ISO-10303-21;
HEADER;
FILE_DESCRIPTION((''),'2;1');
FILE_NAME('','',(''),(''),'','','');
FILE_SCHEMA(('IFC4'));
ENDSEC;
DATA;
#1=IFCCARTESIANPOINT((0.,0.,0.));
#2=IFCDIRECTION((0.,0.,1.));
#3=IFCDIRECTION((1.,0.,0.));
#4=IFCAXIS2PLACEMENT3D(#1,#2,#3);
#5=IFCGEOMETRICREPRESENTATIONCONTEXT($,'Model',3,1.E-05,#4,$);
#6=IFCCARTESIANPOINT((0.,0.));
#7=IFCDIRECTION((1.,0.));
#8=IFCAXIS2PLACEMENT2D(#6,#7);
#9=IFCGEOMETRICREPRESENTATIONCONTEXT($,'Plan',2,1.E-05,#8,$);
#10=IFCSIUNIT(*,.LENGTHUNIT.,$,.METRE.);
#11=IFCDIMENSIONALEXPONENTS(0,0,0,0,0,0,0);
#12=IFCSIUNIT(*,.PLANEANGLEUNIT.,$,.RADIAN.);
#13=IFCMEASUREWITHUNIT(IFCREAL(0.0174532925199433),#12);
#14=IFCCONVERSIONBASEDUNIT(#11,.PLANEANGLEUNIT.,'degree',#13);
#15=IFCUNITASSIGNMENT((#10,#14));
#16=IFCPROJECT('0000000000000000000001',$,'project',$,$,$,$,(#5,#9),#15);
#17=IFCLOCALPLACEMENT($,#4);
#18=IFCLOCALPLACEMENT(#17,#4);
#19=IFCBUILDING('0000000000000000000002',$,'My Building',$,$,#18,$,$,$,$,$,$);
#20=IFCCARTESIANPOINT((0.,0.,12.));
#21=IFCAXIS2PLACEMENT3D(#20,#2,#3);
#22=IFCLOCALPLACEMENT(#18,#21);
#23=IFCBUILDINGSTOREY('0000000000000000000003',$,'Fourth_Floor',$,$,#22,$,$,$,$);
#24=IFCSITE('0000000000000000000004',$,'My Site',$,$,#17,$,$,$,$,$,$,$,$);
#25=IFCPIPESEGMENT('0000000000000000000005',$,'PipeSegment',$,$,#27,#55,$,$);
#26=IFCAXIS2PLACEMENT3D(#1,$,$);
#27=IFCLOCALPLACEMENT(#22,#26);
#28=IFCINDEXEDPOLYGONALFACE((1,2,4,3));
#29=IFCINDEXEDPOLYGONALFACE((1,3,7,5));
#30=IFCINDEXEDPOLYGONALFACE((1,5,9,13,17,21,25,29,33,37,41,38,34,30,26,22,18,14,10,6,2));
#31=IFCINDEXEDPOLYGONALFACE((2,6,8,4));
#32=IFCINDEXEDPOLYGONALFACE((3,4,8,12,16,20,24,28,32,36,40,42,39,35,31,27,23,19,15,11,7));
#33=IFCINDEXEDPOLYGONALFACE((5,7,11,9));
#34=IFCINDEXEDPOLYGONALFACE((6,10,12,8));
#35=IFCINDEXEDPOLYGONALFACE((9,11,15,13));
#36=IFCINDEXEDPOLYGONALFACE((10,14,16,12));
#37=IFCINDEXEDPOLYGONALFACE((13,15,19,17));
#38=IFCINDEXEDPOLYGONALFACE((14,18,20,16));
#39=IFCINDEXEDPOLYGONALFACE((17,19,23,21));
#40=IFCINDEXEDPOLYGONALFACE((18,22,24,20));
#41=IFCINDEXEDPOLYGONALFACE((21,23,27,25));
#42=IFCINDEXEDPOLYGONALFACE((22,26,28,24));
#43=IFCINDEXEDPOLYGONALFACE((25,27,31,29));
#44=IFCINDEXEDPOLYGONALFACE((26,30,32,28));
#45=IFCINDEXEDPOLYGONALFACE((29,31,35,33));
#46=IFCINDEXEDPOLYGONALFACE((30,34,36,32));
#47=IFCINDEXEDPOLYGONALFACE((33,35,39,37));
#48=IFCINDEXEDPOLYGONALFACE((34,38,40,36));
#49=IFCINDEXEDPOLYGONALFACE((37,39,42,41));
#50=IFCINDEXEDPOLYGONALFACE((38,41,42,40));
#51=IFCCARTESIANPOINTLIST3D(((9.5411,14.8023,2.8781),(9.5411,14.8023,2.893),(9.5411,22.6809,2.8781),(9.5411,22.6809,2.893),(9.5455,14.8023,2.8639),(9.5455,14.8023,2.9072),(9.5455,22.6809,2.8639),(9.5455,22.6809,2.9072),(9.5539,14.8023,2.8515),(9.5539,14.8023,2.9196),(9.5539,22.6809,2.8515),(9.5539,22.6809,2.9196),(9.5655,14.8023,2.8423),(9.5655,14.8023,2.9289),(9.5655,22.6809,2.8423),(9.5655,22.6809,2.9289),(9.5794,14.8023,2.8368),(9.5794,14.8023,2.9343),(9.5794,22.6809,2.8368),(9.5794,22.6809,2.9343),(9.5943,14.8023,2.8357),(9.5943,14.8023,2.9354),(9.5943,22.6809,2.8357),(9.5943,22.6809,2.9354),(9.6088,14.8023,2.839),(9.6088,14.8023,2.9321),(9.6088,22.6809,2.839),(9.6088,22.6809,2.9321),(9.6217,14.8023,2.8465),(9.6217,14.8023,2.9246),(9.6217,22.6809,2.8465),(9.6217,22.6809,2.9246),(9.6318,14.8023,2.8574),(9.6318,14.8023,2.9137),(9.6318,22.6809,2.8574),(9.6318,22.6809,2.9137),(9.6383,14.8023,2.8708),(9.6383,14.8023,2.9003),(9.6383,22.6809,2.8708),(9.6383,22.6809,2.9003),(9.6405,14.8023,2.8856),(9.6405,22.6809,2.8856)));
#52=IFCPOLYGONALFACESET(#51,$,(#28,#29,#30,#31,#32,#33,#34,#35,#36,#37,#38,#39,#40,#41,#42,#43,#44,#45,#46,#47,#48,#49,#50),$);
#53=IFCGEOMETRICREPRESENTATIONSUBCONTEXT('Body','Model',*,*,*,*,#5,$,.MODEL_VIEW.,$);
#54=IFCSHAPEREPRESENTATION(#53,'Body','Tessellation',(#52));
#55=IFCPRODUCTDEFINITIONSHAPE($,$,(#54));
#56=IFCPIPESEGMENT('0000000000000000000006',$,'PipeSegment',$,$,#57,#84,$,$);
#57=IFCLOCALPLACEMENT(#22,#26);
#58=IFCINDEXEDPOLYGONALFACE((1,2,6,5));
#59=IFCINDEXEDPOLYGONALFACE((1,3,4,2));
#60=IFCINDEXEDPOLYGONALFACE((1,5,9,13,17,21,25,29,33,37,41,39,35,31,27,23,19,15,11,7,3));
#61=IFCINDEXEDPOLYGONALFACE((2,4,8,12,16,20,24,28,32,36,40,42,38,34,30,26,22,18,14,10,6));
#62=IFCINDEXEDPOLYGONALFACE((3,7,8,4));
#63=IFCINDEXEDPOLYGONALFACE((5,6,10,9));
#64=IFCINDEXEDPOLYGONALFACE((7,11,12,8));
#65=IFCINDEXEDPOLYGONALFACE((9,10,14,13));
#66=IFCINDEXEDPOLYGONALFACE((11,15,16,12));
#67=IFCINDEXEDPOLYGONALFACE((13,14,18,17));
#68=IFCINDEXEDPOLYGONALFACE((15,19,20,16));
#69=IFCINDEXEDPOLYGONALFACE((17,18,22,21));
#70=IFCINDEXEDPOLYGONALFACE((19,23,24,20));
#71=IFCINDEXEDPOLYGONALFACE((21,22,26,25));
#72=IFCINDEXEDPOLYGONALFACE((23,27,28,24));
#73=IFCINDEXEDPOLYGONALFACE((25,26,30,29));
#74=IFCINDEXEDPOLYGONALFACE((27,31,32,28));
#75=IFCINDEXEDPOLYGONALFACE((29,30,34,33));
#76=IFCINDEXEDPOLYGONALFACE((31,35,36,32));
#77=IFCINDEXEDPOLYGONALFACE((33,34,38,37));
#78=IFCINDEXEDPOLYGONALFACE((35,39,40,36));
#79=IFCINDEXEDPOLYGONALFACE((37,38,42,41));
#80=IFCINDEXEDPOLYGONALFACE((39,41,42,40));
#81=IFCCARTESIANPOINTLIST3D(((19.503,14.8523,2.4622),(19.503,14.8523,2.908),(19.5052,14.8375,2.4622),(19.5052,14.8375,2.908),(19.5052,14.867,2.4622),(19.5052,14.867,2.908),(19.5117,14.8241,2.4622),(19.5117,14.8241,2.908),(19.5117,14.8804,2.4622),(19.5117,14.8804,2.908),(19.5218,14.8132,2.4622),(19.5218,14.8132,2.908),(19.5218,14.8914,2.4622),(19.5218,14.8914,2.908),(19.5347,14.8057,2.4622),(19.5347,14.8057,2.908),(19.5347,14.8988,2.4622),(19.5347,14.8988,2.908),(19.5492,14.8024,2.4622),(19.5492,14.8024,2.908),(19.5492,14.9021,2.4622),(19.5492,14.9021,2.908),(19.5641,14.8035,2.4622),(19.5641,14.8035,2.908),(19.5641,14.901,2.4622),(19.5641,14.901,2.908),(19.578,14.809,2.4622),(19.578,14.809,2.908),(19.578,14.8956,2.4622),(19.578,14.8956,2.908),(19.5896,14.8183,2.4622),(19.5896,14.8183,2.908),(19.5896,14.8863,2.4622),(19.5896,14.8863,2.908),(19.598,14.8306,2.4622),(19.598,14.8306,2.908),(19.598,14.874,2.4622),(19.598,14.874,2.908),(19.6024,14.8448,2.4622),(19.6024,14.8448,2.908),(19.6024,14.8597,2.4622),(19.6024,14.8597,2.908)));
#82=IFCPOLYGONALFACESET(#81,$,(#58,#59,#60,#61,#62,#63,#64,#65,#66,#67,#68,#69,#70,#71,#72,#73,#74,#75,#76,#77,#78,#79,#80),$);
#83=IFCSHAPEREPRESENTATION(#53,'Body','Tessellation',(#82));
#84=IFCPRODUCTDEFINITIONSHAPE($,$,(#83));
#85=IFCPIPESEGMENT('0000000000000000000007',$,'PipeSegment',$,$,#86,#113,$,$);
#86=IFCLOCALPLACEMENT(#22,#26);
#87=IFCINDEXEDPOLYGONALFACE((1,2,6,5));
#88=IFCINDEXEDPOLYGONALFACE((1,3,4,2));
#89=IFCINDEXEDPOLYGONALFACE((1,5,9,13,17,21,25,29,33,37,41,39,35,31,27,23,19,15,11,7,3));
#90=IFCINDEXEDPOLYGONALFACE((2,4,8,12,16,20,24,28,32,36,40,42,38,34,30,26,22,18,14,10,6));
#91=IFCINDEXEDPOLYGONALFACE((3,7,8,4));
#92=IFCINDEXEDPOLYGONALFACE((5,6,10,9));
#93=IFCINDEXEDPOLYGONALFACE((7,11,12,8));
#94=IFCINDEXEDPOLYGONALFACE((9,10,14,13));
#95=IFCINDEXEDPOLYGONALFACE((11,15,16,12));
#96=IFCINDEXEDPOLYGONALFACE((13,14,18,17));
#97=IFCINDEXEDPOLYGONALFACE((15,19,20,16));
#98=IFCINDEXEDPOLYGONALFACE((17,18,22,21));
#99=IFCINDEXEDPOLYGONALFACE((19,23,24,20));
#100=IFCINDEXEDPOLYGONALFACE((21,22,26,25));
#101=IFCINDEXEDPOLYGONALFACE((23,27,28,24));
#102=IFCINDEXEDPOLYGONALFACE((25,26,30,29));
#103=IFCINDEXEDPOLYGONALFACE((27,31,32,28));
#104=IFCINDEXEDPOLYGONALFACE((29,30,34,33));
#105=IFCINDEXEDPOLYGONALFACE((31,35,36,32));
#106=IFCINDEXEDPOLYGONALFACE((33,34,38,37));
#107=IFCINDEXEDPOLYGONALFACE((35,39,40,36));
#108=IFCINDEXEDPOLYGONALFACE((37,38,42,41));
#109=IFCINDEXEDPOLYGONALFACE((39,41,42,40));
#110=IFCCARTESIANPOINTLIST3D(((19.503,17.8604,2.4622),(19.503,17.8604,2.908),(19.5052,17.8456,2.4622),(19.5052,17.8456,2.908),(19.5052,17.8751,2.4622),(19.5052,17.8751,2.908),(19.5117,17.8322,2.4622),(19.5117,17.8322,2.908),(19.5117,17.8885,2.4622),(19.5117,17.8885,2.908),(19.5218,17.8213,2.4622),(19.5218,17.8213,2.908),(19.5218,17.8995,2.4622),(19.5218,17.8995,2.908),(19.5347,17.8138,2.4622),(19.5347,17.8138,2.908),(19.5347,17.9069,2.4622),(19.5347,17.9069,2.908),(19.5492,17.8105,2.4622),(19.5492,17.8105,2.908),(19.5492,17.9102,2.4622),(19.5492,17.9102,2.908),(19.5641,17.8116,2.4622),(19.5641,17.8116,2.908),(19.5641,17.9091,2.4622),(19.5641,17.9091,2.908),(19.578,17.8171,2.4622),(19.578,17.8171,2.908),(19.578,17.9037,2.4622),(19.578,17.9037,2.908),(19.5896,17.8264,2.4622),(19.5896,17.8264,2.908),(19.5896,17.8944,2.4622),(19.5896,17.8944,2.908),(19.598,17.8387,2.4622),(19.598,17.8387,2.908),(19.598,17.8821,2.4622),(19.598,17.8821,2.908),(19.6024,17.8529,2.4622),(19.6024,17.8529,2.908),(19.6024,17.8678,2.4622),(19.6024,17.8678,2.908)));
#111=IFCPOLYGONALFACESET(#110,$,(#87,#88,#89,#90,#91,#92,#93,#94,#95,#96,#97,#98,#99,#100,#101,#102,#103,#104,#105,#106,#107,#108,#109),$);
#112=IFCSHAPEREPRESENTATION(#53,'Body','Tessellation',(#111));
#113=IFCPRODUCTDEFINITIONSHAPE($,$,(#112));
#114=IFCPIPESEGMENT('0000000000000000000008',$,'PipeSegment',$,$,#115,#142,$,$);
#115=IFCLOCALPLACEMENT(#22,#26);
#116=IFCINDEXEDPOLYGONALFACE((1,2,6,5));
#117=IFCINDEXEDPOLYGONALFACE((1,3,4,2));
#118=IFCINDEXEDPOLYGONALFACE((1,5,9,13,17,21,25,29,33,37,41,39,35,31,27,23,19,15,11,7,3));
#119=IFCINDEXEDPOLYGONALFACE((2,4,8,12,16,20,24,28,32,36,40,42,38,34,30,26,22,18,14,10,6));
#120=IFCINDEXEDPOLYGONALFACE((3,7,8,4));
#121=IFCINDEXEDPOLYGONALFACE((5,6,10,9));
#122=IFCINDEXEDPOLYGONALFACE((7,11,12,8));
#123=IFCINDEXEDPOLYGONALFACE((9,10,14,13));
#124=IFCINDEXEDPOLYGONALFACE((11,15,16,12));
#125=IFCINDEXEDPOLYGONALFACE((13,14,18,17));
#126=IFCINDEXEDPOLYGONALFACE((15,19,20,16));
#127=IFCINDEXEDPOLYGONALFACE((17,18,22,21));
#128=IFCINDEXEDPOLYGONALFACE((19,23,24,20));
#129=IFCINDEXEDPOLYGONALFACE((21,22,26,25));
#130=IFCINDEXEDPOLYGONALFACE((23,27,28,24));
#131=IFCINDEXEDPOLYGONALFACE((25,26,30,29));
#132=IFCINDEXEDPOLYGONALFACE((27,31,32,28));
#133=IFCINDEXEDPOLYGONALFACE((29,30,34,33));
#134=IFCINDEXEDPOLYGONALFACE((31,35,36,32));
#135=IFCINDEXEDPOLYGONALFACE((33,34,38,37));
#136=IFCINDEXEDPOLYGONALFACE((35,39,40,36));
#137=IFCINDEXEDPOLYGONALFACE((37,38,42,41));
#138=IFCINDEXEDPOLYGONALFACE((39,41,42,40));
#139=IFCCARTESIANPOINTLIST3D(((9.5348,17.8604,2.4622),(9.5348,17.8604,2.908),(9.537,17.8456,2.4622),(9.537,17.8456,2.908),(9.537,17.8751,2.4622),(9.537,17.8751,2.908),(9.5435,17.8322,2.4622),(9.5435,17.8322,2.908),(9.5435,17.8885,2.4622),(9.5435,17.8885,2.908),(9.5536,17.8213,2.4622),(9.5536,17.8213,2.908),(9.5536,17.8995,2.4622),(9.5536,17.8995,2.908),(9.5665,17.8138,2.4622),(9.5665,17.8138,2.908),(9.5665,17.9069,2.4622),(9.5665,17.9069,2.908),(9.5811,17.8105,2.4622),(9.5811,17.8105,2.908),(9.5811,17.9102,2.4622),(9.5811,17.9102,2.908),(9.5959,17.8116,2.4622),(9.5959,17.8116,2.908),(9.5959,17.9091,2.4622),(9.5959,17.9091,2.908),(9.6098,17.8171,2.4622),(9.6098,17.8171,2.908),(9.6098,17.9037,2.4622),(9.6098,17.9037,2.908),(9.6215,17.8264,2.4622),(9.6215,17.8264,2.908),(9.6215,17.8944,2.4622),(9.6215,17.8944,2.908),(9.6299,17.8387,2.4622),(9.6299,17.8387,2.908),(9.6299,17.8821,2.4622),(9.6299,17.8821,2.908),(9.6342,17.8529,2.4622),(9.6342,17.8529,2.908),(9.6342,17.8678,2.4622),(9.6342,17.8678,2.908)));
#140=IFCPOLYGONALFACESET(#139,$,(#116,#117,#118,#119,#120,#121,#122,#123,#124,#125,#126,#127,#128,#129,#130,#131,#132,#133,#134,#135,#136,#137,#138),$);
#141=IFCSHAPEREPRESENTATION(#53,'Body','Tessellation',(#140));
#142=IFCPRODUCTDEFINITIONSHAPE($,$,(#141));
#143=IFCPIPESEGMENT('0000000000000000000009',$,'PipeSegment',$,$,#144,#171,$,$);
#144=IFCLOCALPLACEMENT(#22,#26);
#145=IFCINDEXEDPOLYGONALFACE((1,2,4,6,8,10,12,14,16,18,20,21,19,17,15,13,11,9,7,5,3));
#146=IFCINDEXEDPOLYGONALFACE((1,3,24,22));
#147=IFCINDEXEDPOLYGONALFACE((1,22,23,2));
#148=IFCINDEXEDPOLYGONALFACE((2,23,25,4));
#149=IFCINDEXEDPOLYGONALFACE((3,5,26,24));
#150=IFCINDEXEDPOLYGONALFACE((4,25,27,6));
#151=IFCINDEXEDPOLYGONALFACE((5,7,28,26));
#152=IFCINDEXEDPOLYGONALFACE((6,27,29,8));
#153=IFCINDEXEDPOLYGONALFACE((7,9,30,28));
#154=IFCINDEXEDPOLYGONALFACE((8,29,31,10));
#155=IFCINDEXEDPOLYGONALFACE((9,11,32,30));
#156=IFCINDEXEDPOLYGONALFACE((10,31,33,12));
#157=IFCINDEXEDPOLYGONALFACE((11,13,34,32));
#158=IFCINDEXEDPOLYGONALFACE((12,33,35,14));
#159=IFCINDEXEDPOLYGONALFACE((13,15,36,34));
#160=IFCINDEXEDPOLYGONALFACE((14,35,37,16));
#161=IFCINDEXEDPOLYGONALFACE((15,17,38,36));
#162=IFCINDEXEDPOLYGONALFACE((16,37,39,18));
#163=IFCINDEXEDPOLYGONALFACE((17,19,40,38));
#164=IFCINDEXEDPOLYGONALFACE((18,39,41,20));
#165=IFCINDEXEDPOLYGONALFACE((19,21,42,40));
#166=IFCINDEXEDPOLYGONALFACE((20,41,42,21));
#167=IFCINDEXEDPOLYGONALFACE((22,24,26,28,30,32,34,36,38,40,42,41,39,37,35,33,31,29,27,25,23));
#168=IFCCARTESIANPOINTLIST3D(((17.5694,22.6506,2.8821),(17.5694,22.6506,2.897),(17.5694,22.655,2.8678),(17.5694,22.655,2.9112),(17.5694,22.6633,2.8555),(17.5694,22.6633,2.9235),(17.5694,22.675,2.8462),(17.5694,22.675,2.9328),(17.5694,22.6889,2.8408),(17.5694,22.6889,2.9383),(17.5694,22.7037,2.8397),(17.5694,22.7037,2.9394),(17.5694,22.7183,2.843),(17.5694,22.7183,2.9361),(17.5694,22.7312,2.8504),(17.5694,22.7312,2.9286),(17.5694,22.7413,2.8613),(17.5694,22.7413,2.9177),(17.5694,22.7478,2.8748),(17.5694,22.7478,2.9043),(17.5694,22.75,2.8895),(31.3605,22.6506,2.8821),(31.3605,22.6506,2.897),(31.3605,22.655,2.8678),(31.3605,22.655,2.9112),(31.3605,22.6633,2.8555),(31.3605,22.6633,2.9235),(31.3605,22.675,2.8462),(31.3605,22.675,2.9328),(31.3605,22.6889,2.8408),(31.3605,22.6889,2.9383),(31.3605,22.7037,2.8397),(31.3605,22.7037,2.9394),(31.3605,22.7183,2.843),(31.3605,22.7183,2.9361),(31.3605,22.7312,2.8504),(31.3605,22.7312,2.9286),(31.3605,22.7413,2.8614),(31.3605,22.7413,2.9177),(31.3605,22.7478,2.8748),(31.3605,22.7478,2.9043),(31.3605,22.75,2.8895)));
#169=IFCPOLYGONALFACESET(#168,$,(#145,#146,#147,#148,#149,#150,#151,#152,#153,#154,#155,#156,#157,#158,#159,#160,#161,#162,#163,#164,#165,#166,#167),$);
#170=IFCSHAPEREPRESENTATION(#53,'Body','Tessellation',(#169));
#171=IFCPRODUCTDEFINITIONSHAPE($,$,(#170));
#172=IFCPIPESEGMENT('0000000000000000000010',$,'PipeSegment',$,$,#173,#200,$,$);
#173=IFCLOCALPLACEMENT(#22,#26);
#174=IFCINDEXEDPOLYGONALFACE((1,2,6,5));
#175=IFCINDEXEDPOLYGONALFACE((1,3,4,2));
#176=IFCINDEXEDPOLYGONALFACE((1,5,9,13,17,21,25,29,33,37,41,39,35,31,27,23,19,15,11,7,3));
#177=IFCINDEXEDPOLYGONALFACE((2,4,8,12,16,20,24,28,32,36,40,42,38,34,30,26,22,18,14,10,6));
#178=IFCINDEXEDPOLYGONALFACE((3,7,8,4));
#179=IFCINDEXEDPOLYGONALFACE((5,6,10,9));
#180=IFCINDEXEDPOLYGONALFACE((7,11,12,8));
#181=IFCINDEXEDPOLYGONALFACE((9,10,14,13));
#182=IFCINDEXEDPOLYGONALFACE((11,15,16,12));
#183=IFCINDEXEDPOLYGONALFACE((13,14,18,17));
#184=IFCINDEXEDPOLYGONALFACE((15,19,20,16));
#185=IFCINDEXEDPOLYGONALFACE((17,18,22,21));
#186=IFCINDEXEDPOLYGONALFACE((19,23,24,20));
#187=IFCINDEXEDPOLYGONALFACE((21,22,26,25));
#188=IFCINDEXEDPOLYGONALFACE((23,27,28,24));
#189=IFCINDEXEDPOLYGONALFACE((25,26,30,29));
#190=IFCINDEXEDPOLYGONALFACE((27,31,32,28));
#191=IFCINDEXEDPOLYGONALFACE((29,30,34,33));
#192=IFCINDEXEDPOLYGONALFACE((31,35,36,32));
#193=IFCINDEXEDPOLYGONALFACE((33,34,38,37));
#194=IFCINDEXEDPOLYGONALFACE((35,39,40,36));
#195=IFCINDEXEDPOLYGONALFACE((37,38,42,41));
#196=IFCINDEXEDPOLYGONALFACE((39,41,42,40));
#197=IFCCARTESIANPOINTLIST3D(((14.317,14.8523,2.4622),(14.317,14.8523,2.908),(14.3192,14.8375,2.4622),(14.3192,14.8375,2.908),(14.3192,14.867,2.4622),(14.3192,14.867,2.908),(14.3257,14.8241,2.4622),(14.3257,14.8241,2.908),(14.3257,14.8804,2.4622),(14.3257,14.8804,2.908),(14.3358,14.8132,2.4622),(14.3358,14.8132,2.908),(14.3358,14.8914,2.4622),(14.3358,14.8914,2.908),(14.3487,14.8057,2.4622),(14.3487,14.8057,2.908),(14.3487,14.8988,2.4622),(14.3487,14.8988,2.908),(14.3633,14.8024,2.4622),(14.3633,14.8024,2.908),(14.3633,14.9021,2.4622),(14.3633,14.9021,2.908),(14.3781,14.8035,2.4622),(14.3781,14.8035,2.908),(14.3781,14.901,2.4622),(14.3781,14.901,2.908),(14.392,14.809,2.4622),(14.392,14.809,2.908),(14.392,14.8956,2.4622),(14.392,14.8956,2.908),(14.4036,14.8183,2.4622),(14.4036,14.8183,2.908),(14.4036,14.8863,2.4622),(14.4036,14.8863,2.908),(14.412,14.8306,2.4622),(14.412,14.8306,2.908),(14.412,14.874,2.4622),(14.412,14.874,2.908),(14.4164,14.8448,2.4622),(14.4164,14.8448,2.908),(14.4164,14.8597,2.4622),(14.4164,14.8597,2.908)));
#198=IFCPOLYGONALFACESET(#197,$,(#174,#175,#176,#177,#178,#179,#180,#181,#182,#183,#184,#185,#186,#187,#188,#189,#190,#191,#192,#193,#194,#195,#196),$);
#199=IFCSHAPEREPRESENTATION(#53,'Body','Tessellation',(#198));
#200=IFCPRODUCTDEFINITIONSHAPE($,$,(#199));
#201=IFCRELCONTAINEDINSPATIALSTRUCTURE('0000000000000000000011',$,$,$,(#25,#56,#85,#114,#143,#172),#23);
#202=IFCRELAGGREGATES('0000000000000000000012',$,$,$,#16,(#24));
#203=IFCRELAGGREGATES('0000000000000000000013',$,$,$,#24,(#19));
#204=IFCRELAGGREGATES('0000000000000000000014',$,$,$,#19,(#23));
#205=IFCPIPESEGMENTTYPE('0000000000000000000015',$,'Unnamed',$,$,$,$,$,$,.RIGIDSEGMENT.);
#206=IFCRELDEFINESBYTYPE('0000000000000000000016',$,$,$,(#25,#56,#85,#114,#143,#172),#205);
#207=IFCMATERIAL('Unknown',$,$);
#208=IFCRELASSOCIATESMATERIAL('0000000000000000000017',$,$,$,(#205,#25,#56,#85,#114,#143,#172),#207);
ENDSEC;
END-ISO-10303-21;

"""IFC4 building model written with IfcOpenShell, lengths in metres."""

from ifc_helpers import new_model, entity, si_unit, converted_unit, frame, origin_with_axes, origin_2d_with_axis, place, context, subcontext, project, spatial, circle, extrude, material, material_profile, profile_set, profile_usage, type_object, element, save


model = new_model("IFC4")

# Units and contexts
model_context = context("Model", 3, precision=1e-05, world=origin_with_axes())
plan_context = context("Plan", 2, precision=1e-05, world=origin_2d_with_axis())
body_context = subcontext(model_context, "Body", "Model", "MODEL_VIEW")
ifc_project = project(units=[si_unit("LENGTHUNIT", "METRE"), converted_unit("PLANEANGLEUNIT", "degree", entity("IfcReal", 0.0174532925199433), si_unit("PLANEANGLEUNIT", "RADIAN"), dimensions=[0, 0, 0, 0, 0, 0, 0])], contexts=[model_context, plan_context])

# Site, building, storey
site_placement = place(None, origin_with_axes())
site = spatial("IfcSite", under=ifc_project, at=site_placement, Name="My Site")
building_placement = place(site_placement, origin_with_axes())
building = spatial("IfcBuilding", under=site, at=building_placement, Name="My Building")
storey_placement = place(building_placement, frame((0.0, 0.0, 12.0), z_axis=(0.0, 0.0, 1.0), x_axis=(1.0, 0.0, 0.0)))
storey = spatial("IfcBuildingStorey", under=building, at=storey_placement, Name="Fourth_Floor")

# Shared definitions
ifc_material = material(Name="Unknown")

# Pipe segments
ifc_material_profile_1 = material_profile(ifc_material, circle(Radius=0.05))
ifc_profile_set_1 = profile_set([ifc_material_profile_1])
pipe_segment_type = type_object("IfcPipeSegmentType", Name="Unnamed", PredefinedType="RIGIDSEGMENT", material=ifc_profile_set_1)
ifc_profile_usage_1 = profile_usage(ifc_profile_set_1, cardinal=5)
pipe_segment_1_placement = place(storey_placement, frame((9.5905, 22.6809, 2.8856), z_axis=(0.0, -1.0, 0.0), x_axis=(1.0, 0.0, 0.0)))
element("IfcPipeSegment", 1, at=pipe_segment_1_placement, inside=storey, type_object=pipe_segment_type, material=ifc_profile_usage_1, Name="PipeSegment", context=body_context, shape_type="SweptSolid", body=[
    extrude(circle(Radius=0.05), origin_with_axes(), (0.0, 0.0, 1.0), 7.8786),
])
ifc_profile_usage_2 = profile_usage(ifc_profile_set_1, cardinal=5)
pipe_segment_2_placement = place(storey_placement, frame((19.553, 14.8523, 2.908), z_axis=(0.0, 0.0, -1.0), x_axis=(-1.0, 0.0, 0.0)))
element("IfcPipeSegment", 2, at=pipe_segment_2_placement, inside=storey, type_object=pipe_segment_type, material=ifc_profile_usage_2, Name="PipeSegment", context=body_context, shape_type="SweptSolid", body=[
    extrude(circle(Radius=0.05), origin_with_axes(), (0.0, 0.0, 1.0), 0.4458),
])
ifc_profile_usage_3 = profile_usage(ifc_profile_set_1, cardinal=5)
pipe_segment_3_placement = place(storey_placement, frame((19.553, 17.8604, 2.908), z_axis=(0.0, 0.0, -1.0), x_axis=(-1.0, 0.0, 0.0)))
element("IfcPipeSegment", 3, at=pipe_segment_3_placement, inside=storey, type_object=pipe_segment_type, material=ifc_profile_usage_3, Name="PipeSegment", context=body_context, shape_type="SweptSolid", body=[
    extrude(circle(Radius=0.05), origin_with_axes(), (0.0, 0.0, 1.0), 0.4458),
])
ifc_profile_usage_4 = profile_usage(ifc_profile_set_1, cardinal=5)
pipe_segment_4_placement = place(storey_placement, frame((9.5848, 17.8604, 2.908), z_axis=(0.0, 0.0, -1.0), x_axis=(-1.0, 0.0, 0.0)))
element("IfcPipeSegment", 4, at=pipe_segment_4_placement, inside=storey, type_object=pipe_segment_type, material=ifc_profile_usage_4, Name="PipeSegment", context=body_context, shape_type="SweptSolid", body=[
    extrude(circle(Radius=0.05), origin_with_axes(), (0.0, 0.0, 1.0), 0.4458),
])
ifc_profile_usage_5 = profile_usage(ifc_profile_set_1, cardinal=1)
pipe_segment_5_placement = place(storey_placement, frame((17.5694, 22.75, 2.8395), z_axis=(1.0, 0.0, 0.0), x_axis=(0.0, 1.0, 0.0)))
element("IfcPipeSegment", 5, at=pipe_segment_5_placement, inside=storey, type_object=pipe_segment_type, material=ifc_profile_usage_5, Name="PipeSegment", context=body_context, shape_type="SweptSolid", body=[
    extrude(circle(Radius=0.05), frame((-0.05, 0.05, 0.0), z_axis=(0.0, 0.0, 1.0), x_axis=(1.0, 0.0, 0.0)), (0.0, 0.0, 1.0), 13.7911),
])
ifc_profile_usage_6 = profile_usage(ifc_profile_set_1, cardinal=5)
pipe_segment_6_placement = place(storey_placement, frame((14.367, 14.8523, 2.908), z_axis=(0.0, 0.0, -1.0), x_axis=(-1.0, 0.0, 0.0)))
element("IfcPipeSegment", 6, at=pipe_segment_6_placement, inside=storey, type_object=pipe_segment_type, material=ifc_profile_usage_6, Name="PipeSegment", context=body_context, shape_type="SweptSolid", body=[
    extrude(circle(Radius=0.05), origin_with_axes(), (0.0, 0.0, 1.0), 0.4458),
])

save(model, "model.ifc")
